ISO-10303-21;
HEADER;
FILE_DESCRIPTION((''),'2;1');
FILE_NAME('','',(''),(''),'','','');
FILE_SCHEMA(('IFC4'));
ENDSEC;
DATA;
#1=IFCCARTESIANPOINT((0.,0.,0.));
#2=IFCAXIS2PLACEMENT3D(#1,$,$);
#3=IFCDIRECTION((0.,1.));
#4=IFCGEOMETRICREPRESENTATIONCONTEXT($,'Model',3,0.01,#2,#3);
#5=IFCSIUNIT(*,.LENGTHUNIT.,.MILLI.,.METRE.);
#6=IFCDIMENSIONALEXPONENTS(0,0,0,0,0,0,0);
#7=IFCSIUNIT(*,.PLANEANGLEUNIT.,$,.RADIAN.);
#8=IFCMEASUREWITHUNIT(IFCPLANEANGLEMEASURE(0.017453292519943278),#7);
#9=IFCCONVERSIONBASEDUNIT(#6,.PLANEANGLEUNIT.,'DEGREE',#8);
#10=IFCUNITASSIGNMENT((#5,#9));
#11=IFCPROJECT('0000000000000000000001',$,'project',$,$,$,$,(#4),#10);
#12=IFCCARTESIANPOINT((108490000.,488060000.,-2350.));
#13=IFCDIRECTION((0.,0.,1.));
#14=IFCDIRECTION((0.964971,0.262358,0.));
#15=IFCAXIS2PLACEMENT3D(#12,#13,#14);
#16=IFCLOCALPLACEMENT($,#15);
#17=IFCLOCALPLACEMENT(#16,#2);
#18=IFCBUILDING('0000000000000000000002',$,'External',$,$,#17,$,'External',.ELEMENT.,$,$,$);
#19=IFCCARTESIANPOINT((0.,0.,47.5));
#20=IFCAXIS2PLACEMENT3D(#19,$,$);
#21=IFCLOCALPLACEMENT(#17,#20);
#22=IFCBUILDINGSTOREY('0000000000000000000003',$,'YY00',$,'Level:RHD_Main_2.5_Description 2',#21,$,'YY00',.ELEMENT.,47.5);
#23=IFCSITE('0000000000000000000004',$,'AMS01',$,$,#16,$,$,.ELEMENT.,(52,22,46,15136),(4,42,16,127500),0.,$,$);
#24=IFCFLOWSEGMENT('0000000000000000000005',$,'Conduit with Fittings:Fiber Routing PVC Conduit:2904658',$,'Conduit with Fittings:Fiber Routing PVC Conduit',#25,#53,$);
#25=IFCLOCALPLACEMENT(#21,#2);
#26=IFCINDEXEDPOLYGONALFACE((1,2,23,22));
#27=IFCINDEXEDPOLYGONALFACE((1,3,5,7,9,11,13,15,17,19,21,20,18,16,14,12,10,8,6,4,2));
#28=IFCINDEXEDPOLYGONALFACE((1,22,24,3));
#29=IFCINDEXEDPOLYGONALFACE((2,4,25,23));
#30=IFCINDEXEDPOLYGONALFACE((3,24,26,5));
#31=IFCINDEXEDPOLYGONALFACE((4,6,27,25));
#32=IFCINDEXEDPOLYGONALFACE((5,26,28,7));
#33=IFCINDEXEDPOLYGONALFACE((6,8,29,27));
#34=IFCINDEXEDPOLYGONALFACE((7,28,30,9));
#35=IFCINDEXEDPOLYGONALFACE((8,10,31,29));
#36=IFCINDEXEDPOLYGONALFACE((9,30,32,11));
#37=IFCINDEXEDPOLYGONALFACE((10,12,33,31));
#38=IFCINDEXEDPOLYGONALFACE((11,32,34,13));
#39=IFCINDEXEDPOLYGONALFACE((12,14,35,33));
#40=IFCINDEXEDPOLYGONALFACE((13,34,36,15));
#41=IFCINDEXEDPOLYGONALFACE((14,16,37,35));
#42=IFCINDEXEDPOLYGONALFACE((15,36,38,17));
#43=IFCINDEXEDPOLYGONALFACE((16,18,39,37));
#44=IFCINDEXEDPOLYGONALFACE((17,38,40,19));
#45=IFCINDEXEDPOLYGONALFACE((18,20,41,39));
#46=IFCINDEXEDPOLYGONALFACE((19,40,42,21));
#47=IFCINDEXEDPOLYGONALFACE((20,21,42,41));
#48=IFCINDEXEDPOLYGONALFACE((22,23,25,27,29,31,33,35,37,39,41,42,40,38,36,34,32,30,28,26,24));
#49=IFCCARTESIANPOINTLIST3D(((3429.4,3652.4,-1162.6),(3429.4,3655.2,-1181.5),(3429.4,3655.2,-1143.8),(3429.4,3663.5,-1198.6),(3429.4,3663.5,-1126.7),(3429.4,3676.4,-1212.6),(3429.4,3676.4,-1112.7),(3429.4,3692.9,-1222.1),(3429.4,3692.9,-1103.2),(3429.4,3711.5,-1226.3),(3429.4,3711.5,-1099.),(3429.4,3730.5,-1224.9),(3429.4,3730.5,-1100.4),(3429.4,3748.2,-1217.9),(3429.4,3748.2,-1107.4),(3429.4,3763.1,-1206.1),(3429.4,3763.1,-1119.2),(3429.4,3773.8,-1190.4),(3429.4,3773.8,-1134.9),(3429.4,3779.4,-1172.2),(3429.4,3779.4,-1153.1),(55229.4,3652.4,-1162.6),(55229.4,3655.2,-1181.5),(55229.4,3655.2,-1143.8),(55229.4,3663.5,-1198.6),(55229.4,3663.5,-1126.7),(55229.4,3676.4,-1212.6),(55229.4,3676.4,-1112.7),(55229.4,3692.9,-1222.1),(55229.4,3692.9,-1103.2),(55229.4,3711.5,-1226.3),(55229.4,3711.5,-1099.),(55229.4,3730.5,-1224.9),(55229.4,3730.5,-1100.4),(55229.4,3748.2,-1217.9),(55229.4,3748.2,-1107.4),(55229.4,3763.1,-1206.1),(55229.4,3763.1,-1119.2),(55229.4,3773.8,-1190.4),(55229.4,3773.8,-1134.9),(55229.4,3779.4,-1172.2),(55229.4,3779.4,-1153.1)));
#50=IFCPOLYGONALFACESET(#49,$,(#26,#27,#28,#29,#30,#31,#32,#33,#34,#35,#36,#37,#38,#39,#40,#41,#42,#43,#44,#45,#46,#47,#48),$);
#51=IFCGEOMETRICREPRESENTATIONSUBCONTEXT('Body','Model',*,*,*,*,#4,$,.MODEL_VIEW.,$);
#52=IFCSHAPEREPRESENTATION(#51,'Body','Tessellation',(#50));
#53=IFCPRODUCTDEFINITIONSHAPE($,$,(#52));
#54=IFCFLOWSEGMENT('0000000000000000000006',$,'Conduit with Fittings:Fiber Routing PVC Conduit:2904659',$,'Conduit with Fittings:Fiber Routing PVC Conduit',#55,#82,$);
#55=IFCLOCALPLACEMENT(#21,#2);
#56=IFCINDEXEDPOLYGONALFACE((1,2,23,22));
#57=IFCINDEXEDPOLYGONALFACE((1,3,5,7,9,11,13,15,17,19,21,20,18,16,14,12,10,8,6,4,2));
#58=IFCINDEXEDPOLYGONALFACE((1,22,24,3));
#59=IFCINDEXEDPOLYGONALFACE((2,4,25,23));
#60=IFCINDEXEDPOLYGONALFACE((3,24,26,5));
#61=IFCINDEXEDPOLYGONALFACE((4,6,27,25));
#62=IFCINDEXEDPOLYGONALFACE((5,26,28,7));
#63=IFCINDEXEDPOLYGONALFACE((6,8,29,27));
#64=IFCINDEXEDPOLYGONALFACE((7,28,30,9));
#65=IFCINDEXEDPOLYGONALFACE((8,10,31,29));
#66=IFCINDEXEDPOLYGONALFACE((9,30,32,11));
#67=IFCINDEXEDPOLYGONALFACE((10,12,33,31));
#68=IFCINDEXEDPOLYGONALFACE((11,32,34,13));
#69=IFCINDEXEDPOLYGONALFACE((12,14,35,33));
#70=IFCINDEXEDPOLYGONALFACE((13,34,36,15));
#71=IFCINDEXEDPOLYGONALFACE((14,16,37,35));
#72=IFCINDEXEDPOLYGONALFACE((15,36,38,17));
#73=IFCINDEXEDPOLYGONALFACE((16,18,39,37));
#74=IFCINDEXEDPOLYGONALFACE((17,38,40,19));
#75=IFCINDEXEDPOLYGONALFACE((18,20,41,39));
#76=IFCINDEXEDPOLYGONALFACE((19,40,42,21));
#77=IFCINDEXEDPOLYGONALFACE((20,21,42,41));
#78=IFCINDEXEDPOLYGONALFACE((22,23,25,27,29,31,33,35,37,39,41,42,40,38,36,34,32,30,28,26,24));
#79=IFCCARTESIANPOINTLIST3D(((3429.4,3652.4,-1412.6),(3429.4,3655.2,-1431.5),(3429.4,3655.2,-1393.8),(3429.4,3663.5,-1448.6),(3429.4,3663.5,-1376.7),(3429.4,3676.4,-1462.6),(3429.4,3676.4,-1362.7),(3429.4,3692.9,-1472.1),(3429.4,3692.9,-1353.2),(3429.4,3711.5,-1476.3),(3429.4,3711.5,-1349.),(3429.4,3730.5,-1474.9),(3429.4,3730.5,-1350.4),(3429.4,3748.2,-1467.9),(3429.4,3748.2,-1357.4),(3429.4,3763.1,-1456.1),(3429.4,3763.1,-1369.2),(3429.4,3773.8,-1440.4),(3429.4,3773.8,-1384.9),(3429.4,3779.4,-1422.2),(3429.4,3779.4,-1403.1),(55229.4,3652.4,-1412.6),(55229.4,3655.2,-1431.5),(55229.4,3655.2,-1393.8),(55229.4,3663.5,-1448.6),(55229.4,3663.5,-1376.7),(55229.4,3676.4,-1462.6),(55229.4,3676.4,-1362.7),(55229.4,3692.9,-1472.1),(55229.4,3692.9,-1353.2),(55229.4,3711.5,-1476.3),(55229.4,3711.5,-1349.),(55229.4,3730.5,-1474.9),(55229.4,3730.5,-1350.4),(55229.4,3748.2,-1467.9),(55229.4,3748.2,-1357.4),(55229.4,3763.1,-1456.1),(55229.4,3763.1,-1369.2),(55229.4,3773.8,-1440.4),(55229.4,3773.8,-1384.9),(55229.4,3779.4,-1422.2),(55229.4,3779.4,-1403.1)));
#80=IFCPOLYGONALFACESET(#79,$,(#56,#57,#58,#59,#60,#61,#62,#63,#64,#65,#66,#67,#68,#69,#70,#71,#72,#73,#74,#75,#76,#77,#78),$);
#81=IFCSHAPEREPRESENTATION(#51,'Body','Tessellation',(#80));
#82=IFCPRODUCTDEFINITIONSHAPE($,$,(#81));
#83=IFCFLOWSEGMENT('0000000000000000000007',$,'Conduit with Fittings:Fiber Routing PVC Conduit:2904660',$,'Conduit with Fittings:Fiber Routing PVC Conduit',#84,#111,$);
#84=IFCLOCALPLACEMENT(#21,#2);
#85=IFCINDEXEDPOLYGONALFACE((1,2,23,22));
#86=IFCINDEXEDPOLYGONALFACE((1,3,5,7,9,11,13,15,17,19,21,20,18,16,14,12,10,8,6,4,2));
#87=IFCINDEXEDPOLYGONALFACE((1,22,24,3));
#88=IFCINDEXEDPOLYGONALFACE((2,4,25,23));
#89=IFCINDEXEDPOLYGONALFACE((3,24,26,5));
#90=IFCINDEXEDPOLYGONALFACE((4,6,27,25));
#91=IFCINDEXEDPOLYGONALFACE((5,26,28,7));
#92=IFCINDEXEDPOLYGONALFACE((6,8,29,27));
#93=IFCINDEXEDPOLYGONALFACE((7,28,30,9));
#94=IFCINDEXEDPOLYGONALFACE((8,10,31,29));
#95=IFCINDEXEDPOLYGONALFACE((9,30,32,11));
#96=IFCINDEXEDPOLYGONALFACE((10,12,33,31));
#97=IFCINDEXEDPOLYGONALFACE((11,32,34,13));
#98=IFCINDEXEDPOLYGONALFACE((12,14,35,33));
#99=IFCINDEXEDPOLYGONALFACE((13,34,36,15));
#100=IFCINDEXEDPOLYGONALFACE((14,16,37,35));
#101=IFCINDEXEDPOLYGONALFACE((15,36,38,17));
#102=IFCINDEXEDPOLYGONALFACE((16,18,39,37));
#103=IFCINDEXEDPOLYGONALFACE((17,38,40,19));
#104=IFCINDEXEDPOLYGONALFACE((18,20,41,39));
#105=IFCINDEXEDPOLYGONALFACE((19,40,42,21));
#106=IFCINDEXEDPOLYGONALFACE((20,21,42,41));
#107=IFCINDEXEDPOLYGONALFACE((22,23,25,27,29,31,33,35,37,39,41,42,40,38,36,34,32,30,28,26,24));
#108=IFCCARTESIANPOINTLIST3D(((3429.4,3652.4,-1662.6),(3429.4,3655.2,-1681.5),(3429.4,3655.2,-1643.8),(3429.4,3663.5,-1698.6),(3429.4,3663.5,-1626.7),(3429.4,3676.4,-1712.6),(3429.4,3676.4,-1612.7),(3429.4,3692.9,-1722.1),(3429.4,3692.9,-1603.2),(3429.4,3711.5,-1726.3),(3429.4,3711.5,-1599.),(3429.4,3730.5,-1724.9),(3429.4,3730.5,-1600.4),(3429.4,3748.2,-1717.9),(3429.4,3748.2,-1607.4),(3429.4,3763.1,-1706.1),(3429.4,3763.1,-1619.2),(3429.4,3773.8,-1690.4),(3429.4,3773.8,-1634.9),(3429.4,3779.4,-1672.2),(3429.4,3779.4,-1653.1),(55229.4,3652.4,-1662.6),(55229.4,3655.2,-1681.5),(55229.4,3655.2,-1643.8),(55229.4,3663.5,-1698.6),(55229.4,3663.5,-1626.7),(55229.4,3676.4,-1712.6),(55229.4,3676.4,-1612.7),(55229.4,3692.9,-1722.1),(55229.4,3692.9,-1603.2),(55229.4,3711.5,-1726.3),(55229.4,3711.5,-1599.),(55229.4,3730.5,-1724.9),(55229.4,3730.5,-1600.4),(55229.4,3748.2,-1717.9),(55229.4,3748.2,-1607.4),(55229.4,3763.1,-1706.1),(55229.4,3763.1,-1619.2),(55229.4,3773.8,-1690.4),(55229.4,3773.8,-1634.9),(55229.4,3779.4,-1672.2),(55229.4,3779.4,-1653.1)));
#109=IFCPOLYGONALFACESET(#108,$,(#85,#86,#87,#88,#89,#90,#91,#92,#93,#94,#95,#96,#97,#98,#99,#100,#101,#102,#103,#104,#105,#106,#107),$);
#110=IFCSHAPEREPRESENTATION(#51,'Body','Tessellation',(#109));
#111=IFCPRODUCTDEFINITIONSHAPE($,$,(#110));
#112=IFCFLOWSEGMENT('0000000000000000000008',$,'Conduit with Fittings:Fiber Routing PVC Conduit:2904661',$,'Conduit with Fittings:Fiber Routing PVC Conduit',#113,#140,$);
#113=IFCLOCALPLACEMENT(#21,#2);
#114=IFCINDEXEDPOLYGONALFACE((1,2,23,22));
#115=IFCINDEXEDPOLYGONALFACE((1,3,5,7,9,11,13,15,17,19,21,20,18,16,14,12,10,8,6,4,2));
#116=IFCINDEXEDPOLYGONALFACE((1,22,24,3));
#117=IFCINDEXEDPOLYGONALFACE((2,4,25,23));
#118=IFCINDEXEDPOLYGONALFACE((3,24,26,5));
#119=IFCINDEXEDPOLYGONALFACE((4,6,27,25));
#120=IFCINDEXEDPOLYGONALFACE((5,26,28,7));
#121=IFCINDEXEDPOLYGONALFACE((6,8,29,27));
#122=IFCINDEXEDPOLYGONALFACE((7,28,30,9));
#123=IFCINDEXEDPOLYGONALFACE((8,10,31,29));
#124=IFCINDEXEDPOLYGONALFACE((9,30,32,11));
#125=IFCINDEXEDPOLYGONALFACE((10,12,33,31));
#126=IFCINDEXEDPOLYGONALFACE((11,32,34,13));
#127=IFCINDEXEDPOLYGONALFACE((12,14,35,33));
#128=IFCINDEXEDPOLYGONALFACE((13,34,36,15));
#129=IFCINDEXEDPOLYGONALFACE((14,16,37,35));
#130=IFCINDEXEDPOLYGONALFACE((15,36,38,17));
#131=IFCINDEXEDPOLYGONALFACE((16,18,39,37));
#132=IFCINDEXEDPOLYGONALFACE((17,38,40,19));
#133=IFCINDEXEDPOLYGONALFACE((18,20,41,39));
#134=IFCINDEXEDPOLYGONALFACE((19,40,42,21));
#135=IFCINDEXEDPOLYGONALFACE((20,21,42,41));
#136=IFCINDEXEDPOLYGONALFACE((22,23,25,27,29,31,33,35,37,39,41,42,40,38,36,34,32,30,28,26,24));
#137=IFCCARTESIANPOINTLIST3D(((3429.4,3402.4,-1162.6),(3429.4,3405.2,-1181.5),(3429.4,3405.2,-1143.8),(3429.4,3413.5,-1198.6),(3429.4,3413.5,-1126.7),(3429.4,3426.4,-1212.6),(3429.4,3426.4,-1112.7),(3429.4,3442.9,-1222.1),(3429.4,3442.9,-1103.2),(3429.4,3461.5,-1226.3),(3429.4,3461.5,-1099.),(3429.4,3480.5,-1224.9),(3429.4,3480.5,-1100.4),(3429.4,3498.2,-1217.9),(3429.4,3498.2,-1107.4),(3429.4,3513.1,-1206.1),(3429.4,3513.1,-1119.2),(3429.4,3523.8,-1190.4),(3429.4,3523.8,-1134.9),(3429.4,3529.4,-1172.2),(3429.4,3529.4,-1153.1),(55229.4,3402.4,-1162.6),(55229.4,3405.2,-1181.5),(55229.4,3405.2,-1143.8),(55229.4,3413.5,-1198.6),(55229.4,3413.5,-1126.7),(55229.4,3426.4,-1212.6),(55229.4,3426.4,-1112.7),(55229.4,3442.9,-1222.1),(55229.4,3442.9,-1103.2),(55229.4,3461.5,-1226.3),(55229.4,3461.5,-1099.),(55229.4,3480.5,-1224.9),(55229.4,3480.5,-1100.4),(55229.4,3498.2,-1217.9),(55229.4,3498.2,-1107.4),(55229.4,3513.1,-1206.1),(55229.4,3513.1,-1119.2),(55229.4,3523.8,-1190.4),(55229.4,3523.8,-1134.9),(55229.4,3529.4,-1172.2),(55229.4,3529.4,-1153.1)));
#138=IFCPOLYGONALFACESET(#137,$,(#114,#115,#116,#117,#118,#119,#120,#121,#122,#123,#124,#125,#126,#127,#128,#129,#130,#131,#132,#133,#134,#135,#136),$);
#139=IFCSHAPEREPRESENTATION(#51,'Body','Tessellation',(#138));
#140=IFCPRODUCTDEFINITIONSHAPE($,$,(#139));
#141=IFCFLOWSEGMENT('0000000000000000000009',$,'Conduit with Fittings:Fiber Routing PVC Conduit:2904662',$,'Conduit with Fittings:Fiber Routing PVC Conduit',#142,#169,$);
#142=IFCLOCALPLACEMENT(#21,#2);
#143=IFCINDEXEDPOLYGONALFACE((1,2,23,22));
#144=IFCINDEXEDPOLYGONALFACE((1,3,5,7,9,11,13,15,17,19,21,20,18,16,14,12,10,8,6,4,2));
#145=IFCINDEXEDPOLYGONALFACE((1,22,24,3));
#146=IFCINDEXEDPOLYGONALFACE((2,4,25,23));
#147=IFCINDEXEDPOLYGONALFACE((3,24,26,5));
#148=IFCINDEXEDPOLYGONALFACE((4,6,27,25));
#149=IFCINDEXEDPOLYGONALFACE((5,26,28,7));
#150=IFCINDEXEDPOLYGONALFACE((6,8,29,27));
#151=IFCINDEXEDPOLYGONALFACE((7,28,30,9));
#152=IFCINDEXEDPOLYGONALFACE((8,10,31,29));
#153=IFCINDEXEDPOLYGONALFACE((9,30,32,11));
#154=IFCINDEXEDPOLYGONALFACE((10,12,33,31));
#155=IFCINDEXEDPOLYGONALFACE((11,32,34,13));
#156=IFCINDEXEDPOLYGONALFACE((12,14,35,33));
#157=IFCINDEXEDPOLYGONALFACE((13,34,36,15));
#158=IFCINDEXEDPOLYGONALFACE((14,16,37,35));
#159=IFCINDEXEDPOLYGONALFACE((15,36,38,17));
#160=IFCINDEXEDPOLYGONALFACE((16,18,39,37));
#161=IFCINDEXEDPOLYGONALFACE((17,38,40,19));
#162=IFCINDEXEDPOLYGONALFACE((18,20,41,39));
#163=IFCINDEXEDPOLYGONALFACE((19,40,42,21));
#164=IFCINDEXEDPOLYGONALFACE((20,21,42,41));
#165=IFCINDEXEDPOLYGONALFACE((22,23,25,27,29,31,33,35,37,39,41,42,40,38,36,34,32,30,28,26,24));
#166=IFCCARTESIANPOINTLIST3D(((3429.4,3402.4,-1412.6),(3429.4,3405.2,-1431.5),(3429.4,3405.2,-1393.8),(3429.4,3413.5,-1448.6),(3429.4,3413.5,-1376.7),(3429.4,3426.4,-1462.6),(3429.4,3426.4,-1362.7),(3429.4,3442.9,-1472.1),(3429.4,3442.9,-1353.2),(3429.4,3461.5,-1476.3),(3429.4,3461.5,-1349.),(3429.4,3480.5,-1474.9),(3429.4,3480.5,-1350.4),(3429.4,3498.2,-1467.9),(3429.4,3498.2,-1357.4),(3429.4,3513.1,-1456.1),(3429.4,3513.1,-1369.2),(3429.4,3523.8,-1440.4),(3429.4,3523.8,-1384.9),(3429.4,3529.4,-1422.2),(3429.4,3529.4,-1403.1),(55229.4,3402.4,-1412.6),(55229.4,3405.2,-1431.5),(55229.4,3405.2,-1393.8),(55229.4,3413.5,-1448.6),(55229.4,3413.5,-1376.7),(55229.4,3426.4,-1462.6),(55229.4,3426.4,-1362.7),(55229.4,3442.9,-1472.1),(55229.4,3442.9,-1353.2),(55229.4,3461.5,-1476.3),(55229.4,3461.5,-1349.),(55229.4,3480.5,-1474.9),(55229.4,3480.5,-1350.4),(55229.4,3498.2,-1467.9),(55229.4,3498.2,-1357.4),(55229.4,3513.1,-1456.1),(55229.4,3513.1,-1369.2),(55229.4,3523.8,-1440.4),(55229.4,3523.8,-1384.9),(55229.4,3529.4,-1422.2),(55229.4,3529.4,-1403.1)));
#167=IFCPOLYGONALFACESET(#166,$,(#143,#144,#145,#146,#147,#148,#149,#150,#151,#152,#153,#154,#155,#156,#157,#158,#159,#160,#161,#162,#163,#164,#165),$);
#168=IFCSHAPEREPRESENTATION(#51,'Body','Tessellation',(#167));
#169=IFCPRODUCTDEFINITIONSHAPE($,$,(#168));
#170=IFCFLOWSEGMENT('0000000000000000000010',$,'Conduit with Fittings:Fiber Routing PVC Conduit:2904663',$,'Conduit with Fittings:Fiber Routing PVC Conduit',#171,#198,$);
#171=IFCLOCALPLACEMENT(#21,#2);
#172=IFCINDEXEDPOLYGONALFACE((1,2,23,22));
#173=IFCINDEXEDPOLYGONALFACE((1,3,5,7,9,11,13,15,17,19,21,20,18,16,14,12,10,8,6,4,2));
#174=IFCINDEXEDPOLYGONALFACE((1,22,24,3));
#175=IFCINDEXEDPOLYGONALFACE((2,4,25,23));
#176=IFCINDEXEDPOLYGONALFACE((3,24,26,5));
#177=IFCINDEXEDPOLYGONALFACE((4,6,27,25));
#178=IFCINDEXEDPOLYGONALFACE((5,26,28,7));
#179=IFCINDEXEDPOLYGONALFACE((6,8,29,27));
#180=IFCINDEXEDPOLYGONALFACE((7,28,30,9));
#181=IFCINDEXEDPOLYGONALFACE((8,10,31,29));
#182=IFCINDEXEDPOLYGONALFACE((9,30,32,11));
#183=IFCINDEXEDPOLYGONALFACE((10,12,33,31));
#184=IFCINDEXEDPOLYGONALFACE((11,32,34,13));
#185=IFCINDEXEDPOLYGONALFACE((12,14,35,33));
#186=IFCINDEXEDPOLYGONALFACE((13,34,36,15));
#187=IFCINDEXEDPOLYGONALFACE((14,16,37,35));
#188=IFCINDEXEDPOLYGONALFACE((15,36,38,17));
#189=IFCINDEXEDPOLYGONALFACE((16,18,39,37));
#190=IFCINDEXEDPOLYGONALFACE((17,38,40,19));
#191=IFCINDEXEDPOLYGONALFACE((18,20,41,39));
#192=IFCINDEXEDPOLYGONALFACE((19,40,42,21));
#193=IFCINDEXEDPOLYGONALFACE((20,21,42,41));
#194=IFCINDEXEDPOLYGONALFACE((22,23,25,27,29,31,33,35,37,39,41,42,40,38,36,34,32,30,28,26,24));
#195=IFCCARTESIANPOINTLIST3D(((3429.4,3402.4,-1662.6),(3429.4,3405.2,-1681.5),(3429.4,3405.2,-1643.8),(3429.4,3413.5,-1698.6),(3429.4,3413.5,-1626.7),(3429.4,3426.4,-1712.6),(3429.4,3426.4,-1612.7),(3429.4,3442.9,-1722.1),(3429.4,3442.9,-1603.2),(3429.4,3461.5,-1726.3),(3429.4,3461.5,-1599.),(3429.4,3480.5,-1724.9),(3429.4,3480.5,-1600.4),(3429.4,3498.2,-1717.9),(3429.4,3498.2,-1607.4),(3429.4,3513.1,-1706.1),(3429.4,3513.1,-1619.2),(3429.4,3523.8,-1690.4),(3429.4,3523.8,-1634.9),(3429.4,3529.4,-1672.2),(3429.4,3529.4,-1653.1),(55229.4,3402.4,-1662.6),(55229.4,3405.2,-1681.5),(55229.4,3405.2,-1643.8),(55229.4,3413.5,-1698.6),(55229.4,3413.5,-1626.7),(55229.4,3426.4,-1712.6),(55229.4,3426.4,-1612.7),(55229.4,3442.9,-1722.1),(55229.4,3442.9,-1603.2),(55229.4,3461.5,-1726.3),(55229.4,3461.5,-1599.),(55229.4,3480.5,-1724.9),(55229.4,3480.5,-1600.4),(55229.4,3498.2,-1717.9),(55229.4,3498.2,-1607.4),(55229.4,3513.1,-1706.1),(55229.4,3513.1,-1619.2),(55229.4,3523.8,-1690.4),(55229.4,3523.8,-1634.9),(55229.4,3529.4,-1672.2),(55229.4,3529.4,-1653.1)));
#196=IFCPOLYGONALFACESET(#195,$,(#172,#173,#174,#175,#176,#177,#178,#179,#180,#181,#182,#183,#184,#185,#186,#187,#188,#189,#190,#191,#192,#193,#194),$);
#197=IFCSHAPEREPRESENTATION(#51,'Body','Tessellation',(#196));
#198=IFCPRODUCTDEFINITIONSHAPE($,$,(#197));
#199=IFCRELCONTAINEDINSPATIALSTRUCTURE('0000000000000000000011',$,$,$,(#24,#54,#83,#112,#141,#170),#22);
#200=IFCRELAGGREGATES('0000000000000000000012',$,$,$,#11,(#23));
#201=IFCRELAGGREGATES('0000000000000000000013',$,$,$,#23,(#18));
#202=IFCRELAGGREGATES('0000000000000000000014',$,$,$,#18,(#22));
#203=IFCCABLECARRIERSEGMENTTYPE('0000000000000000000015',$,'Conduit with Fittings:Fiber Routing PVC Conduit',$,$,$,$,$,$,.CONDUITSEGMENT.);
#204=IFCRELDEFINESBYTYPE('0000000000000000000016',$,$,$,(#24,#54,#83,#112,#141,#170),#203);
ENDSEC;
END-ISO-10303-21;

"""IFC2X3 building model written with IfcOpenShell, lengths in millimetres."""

from ifc_helpers import new_model, entity, si_unit, converted_unit, direction, frame, frame_2d, origin, origin_2d_with_axis, place, context, subcontext, project, spatial, circle, extrude, type_object, element, save


model = new_model("IFC2X3")

# Units and contexts
model_context = context("Model", 3, precision=0.01, world=origin(), true_north=direction((0.0, 1.0)))
body_context = subcontext(model_context, "Body", "Model", "MODEL_VIEW")
ifc_project = project(units=[si_unit("LENGTHUNIT", "METRE", prefix="MILLI"), converted_unit("PLANEANGLEUNIT", "DEGREE", entity("IfcPlaneAngleMeasure", 0.017453292519943278), si_unit("PLANEANGLEUNIT", "RADIAN"), dimensions=[0, 0, 0, 0, 0, 0, 0])], contexts=[model_context])

# Site, building, storey
site_placement = place(None, frame((108490000.0, 488060000.0, -2350.0), z_axis=(0.0, 0.0, 1.0), x_axis=(0.964971, 0.262358, 0.0)))
site = spatial("IfcSite", under=ifc_project, at=site_placement, Name="AMS01", CompositionType="ELEMENT", RefLatitude=(52, 22, 46, 15136), RefLongitude=(4, 42, 16, 127500), RefElevation=0.0)
building_placement = place(site_placement, origin())
building = spatial("IfcBuilding", under=site, at=building_placement, Name="External", LongName="External", CompositionType="ELEMENT")
storey_placement = place(building_placement, frame((0.0, 0.0, 47.5)))
storey = spatial("IfcBuildingStorey", under=building, at=storey_placement, Name="YY00", ObjectType="Level:RHD_Main_2.5_Description 2", LongName="YY00", CompositionType="ELEMENT", Elevation=47.5)

# Flow segments
cable_carrier_segment_type = type_object("IfcCableCarrierSegmentType", Name="Conduit with Fittings:Fiber Routing PVC Conduit", PredefinedType="CONDUITSEGMENT")
flow_segment_1_placement = place(storey_placement, origin())
element("IfcFlowSegment", 1, at=flow_segment_1_placement, inside=storey, type_object=cable_carrier_segment_type, Name="Conduit with Fittings:Fiber Routing PVC Conduit:2904658", ObjectType="Conduit with Fittings:Fiber Routing PVC Conduit", context=body_context, shape_type="SweptSolid", body=[
    extrude(circle(Radius=63.9, at=frame_2d((0.0, 0.0), x_axis=(1.0, 0.0))), frame((3429.4, 3716.3, -1162.6), z_axis=(1.0, 0.0, 0.0), x_axis=(0.0, -1.0, 0.0)), (0.0, 0.0, 1.0), 51800.0),
])
flow_segment_2_placement = place(storey_placement, origin())
element("IfcFlowSegment", 2, at=flow_segment_2_placement, inside=storey, type_object=cable_carrier_segment_type, Name="Conduit with Fittings:Fiber Routing PVC Conduit:2904659", ObjectType="Conduit with Fittings:Fiber Routing PVC Conduit", context=body_context, shape_type="SweptSolid", body=[
    extrude(circle(Radius=63.9, at=frame_2d((0.0, 0.0), x_axis=(1.0, 0.0))), frame((3429.4, 3716.3, -1412.6), z_axis=(1.0, 0.0, 0.0), x_axis=(0.0, -1.0, 0.0)), (0.0, 0.0, 1.0), 51800.0),
])
flow_segment_3_placement = place(storey_placement, origin())
element("IfcFlowSegment", 3, at=flow_segment_3_placement, inside=storey, type_object=cable_carrier_segment_type, Name="Conduit with Fittings:Fiber Routing PVC Conduit:2904660", ObjectType="Conduit with Fittings:Fiber Routing PVC Conduit", context=body_context, shape_type="SweptSolid", body=[
    extrude(circle(Radius=63.9, at=origin_2d_with_axis()), frame((3429.4, 3716.3, -1662.6), z_axis=(1.0, 0.0, 0.0), x_axis=(0.0, -1.0, 0.0)), (0.0, 0.0, 1.0), 51800.0),
])
flow_segment_4_placement = place(storey_placement, origin())
element("IfcFlowSegment", 4, at=flow_segment_4_placement, inside=storey, type_object=cable_carrier_segment_type, Name="Conduit with Fittings:Fiber Routing PVC Conduit:2904661", ObjectType="Conduit with Fittings:Fiber Routing PVC Conduit", context=body_context, shape_type="SweptSolid", body=[
    extrude(circle(Radius=63.9, at=frame_2d((0.0, 0.0), x_axis=(1.0, 0.0))), frame((3429.4, 3466.3, -1162.6), z_axis=(1.0, 0.0, 0.0), x_axis=(0.0, -1.0, 0.0)), (0.0, 0.0, 1.0), 51800.0),
])
flow_segment_5_placement = place(storey_placement, origin())
element("IfcFlowSegment", 5, at=flow_segment_5_placement, inside=storey, type_object=cable_carrier_segment_type, Name="Conduit with Fittings:Fiber Routing PVC Conduit:2904662", ObjectType="Conduit with Fittings:Fiber Routing PVC Conduit", context=body_context, shape_type="SweptSolid", body=[
    extrude(circle(Radius=63.9, at=frame_2d((0.0, 0.0), x_axis=(1.0, 0.0))), frame((3429.4, 3466.3, -1412.6), z_axis=(1.0, 0.0, 0.0), x_axis=(0.0, -1.0, 0.0)), (0.0, 0.0, 1.0), 51800.0),
])
flow_segment_6_placement = place(storey_placement, origin())
element("IfcFlowSegment", 6, at=flow_segment_6_placement, inside=storey, type_object=cable_carrier_segment_type, Name="Conduit with Fittings:Fiber Routing PVC Conduit:2904663", ObjectType="Conduit with Fittings:Fiber Routing PVC Conduit", context=body_context, shape_type="SweptSolid", body=[
    extrude(circle(Radius=63.9, at=frame_2d((0.0, 0.0), x_axis=(1.0, 0.0))), frame((3429.4, 3466.3, -1662.6), z_axis=(1.0, 0.0, 0.0), x_axis=(0.0, -1.0, 0.0)), (0.0, 0.0, 1.0), 51800.0),
])

save(model, "model.ifc")
